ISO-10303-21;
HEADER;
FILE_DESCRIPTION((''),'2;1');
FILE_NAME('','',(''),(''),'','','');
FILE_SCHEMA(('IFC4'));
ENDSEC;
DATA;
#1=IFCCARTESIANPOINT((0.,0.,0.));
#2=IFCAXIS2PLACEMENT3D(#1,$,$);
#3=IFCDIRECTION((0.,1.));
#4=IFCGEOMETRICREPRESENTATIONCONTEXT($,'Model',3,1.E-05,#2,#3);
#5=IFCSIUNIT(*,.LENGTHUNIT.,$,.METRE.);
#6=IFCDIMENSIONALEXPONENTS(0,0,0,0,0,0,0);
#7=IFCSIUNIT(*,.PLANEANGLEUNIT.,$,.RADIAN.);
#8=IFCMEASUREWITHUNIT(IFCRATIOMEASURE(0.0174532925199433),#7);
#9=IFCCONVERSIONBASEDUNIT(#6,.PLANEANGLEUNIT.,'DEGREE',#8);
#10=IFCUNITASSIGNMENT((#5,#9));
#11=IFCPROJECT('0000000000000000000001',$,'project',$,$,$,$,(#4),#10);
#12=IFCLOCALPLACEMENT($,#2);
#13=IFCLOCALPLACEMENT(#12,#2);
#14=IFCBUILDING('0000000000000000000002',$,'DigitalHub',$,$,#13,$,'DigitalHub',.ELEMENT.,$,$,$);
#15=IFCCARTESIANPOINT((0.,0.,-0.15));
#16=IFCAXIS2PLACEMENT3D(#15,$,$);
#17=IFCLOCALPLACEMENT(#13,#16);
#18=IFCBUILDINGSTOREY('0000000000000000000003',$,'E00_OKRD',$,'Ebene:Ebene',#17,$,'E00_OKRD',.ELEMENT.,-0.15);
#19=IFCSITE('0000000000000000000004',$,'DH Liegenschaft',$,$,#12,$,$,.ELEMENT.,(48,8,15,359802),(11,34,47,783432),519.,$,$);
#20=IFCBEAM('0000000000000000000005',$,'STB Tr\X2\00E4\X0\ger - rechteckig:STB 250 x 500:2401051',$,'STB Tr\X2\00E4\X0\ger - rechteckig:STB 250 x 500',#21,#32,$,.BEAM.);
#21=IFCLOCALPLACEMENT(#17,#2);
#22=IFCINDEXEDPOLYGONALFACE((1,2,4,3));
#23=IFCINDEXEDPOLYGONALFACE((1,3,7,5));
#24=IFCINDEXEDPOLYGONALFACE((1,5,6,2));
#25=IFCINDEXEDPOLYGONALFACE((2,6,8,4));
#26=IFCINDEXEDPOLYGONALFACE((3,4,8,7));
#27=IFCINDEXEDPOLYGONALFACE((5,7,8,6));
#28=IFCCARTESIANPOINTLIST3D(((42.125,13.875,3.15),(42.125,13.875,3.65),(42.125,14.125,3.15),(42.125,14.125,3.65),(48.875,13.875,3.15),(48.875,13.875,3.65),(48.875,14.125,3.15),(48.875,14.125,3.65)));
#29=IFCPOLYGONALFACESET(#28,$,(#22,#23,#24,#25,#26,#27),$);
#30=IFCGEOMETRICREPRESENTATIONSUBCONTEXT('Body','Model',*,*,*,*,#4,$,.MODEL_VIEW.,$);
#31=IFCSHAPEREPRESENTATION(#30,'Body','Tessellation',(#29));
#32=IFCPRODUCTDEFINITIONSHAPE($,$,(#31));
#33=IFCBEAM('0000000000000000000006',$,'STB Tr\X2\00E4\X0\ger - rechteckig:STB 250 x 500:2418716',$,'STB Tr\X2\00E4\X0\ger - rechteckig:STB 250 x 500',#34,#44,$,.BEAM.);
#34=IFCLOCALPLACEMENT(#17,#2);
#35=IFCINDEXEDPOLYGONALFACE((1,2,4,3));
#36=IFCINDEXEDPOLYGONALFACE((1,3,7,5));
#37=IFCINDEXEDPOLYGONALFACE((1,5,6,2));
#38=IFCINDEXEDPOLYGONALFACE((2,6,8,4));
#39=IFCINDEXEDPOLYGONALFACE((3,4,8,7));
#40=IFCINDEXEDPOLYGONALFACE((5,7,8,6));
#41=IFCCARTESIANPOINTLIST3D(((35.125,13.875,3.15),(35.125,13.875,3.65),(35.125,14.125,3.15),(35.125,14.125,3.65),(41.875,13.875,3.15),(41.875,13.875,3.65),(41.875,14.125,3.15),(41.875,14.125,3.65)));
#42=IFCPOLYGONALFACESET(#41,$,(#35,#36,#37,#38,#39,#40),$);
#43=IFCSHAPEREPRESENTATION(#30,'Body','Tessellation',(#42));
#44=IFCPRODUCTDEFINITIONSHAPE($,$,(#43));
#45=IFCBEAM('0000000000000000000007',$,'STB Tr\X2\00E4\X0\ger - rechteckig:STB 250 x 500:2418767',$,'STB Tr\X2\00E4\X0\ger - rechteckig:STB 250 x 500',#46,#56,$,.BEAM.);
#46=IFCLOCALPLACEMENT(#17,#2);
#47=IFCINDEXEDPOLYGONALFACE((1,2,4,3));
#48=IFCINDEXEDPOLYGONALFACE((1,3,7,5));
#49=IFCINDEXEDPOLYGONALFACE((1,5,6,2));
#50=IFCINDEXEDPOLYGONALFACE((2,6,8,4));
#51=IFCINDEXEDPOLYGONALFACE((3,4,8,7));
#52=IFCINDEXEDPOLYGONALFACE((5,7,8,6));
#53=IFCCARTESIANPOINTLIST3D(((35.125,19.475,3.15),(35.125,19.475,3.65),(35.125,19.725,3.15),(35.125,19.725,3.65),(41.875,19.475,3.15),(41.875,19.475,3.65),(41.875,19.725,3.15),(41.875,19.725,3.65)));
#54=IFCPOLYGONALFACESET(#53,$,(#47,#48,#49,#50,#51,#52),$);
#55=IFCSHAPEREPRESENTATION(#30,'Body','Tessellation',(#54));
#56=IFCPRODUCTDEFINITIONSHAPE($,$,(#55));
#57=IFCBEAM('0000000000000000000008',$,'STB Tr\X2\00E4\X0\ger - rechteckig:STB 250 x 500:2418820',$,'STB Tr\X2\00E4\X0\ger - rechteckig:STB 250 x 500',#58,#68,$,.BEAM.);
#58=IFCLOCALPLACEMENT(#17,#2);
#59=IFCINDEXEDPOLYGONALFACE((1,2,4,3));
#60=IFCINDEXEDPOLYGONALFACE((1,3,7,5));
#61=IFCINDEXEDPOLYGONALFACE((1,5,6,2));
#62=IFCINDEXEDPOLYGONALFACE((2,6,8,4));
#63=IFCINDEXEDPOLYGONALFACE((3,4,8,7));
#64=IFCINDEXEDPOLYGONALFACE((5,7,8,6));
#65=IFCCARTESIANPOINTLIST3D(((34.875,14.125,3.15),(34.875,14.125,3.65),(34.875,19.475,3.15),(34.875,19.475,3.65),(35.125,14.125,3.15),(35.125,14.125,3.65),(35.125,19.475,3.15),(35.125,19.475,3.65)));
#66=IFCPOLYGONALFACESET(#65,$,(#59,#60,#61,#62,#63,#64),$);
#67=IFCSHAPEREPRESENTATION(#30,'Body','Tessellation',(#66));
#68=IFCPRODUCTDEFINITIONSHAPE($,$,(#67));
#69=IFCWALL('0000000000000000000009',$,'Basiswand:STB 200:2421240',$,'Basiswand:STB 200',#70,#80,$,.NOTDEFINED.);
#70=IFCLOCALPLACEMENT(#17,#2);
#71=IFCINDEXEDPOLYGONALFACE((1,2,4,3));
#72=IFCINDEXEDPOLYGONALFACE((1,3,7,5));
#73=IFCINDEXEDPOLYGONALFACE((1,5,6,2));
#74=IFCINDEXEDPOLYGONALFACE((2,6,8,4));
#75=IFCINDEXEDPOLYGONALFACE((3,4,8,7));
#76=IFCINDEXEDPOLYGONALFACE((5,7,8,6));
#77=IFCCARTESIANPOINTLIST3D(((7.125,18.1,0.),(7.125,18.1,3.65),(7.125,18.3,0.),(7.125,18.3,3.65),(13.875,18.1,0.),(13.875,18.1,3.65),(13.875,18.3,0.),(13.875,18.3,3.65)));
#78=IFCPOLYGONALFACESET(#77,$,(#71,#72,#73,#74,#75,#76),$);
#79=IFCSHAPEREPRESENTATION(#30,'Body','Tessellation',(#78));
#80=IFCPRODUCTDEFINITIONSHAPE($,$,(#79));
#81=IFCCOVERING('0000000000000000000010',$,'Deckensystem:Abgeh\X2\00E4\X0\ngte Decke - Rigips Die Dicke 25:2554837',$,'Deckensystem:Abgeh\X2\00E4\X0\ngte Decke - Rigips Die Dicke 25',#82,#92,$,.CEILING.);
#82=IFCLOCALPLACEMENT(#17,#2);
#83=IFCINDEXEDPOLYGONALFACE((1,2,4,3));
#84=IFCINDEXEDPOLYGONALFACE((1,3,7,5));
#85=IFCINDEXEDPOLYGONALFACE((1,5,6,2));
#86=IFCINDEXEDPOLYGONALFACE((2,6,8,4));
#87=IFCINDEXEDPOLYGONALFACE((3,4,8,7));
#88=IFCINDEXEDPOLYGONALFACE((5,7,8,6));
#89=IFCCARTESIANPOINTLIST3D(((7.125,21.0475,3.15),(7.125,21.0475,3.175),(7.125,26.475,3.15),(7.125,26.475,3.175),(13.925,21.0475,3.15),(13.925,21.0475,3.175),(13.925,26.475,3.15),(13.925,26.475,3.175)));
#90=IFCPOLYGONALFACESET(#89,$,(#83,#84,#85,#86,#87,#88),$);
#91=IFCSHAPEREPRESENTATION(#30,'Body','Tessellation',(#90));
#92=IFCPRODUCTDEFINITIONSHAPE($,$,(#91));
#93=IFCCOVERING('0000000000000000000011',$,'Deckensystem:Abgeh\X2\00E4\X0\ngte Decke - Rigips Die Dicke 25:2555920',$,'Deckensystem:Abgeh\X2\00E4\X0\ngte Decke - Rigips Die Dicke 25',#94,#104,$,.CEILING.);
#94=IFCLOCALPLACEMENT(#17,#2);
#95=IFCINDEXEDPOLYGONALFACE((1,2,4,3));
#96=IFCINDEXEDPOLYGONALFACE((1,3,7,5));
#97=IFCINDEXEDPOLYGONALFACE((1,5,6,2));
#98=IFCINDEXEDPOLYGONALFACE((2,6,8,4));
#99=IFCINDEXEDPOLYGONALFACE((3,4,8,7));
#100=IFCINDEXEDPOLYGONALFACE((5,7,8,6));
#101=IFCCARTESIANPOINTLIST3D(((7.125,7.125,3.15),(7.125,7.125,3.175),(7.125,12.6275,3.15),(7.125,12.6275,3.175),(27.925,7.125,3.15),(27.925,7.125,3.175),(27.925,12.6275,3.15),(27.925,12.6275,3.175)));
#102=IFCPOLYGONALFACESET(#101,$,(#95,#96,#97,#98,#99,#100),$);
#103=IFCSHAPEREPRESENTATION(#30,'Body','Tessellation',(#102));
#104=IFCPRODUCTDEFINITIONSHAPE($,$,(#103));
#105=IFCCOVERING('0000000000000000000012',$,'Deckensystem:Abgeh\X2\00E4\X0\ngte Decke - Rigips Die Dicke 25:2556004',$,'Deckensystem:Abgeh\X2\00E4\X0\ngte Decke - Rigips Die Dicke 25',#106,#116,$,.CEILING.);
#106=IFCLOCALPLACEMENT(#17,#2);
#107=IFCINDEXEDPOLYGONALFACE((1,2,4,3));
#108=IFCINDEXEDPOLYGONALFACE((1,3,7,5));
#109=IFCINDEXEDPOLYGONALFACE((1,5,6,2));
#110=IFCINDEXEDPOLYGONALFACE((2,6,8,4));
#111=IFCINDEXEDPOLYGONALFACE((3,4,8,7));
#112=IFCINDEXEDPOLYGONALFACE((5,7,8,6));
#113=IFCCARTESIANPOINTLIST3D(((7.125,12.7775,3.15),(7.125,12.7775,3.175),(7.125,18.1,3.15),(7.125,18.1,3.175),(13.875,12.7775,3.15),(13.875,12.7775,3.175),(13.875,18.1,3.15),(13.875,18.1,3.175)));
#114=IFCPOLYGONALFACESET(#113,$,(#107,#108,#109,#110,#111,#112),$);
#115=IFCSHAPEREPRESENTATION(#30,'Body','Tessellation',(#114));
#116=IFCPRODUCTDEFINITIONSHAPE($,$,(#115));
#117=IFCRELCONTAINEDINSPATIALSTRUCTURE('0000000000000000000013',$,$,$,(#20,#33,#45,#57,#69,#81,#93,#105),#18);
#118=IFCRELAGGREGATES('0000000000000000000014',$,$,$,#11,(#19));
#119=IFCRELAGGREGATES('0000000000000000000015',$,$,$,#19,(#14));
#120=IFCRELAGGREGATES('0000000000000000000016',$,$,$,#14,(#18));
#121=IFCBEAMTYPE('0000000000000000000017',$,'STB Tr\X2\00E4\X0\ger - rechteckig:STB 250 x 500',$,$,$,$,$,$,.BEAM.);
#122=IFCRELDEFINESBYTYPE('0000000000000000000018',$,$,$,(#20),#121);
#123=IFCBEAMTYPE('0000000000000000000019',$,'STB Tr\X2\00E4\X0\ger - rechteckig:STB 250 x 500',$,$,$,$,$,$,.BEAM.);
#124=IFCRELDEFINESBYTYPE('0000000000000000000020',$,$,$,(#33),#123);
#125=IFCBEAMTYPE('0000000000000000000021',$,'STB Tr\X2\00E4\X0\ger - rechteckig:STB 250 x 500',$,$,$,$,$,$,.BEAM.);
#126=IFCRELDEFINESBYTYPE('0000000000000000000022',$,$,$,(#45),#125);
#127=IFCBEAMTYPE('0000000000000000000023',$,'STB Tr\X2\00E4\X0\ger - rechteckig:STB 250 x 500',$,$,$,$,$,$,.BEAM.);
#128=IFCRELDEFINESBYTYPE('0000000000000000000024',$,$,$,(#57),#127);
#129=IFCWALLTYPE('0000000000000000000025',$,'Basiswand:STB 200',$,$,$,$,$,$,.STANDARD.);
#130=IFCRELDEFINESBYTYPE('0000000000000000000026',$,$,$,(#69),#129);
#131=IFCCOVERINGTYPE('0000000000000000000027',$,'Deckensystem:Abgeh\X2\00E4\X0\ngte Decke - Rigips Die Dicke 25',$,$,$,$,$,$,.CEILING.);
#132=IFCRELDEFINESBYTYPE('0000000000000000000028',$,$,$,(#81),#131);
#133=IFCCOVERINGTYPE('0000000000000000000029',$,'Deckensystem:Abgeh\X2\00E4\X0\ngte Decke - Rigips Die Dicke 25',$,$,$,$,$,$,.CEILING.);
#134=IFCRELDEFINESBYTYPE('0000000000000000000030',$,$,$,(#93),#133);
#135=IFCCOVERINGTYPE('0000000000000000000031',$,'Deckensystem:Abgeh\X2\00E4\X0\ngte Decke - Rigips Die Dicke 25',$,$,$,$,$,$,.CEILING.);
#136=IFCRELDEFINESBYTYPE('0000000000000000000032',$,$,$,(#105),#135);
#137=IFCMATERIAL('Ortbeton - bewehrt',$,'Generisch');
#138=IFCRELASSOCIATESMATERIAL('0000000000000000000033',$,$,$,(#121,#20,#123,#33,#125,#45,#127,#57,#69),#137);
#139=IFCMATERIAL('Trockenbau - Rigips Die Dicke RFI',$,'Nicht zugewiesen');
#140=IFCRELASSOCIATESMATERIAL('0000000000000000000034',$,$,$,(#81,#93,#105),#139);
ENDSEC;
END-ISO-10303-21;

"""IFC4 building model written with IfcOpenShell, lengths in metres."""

from ifc_helpers import new_model, entity, si_unit, converted_unit, direction, frame, origin, place, context, subcontext, project, spatial, indexed_curve, outline, extrude, source, transform, mapped, material, type_object, type_shapes, element, save


model = new_model("IFC4")

# Units and contexts
model_context = context("Model", 3, precision=1e-05, world=origin(), true_north=direction((0.0, 1.0)))
body_context = subcontext(model_context, "Body", "Model", "MODEL_VIEW")
ifc_project = project(units=[si_unit("LENGTHUNIT", "METRE"), converted_unit("PLANEANGLEUNIT", "DEGREE", entity("IfcRatioMeasure", 0.0174532925199433), si_unit("PLANEANGLEUNIT", "RADIAN"), dimensions=[0, 0, 0, 0, 0, 0, 0])], contexts=[model_context])

# Site, building, storey
site_placement = place(None, frame((0.0, 0.0, 0.0)))
site = spatial("IfcSite", under=ifc_project, at=site_placement, Name="DH Liegenschaft", CompositionType="ELEMENT", RefLatitude=(48, 8, 15, 359802), RefLongitude=(11, 34, 47, 783432), RefElevation=519.0)
building_placement = place(site_placement, origin())
building = spatial("IfcBuilding", under=site, at=building_placement, Name="DigitalHub", LongName="DigitalHub", CompositionType="ELEMENT")
storey_placement = place(building_placement, frame((0.0, 0.0, -0.15)))
storey = spatial("IfcBuildingStorey", under=building, at=storey_placement, Name="E00_OKRD", ObjectType="Ebene:Ebene", LongName="E00_OKRD", CompositionType="ELEMENT", Elevation=-0.15)

# Shared definitions
ifc_material_1 = material(Name="Ortbeton - bewehrt", Category="Generisch")

# Beams
beam_type_1 = type_object("IfcBeamType", Name="STB Träger - rechteckig:STB 250 x 500", PredefinedType="BEAM", material=ifc_material_1)
shared_shape_1 = source(origin(), body_context, "Body", "SweptSolid", [
    extrude(outline(indexed_curve([(-0.25, -0.125), (0.25, -0.125), (0.25, 0.125), (-0.25, 0.125), (-0.25, -0.125)], self_intersect=False)), frame((48.875, 14.0, 3.25), z_axis=(-1.0, 0.0, 0.0), x_axis=(0.0, 0.0, -1.0)), (0.0, 0.0, 1.0), 6.75),
])
type_shapes(beam_type_1, [shared_shape_1])
beam_1_placement = place(storey_placement, frame((0.0, 0.0, 0.15)))
element("IfcBeam", 1, at=beam_1_placement, inside=storey, type_object=beam_type_1, material=ifc_material_1, Name="STB Träger - rechteckig:STB 250 x 500:2401051", ObjectType="STB Träger - rechteckig:STB 250 x 500", PredefinedType="BEAM", context=body_context, shape_type="MappedRepresentation", body=[
    mapped(shared_shape_1, transform((0.0, 0.0, 0.0), scale=1.0)),
])
beam_type_2 = type_object("IfcBeamType", Name="STB Träger - rechteckig:STB 250 x 500", PredefinedType="BEAM", material=ifc_material_1)
shared_shape_2 = source(origin(), body_context, "Body", "SweptSolid", [
    extrude(outline(indexed_curve([(-0.25, -0.125), (0.25, -0.125), (0.25, 0.125), (-0.25, 0.125), (-0.25, -0.125)], self_intersect=False)), frame((41.875, 14.0, 3.25), z_axis=(-1.0, 0.0, 0.0), x_axis=(0.0, 0.0, -1.0)), (0.0, 0.0, 1.0), 6.75),
])
type_shapes(beam_type_2, [shared_shape_2])
beam_2_placement = place(storey_placement, frame((0.0, 0.0, 0.15)))
element("IfcBeam", 2, at=beam_2_placement, inside=storey, type_object=beam_type_2, material=ifc_material_1, Name="STB Träger - rechteckig:STB 250 x 500:2418716", ObjectType="STB Träger - rechteckig:STB 250 x 500", PredefinedType="BEAM", context=body_context, shape_type="MappedRepresentation", body=[
    mapped(shared_shape_2, transform((0.0, 0.0, 0.0), scale=1.0)),
])
beam_type_3 = type_object("IfcBeamType", Name="STB Träger - rechteckig:STB 250 x 500", PredefinedType="BEAM", material=ifc_material_1)
shared_shape_3 = source(origin(), body_context, "Body", "SweptSolid", [
    extrude(outline(indexed_curve([(-0.25, -0.125), (0.25, -0.125), (0.25, 0.125), (-0.25, 0.125), (-0.25, -0.125)], self_intersect=False)), frame((35.125, 19.6, 3.25), z_axis=(1.0, 0.0, 0.0), x_axis=(0.0, 0.0, -1.0)), (0.0, 0.0, 1.0), 6.75),
])
type_shapes(beam_type_3, [shared_shape_3])
beam_3_placement = place(storey_placement, frame((0.0, 0.0, 0.15)))
element("IfcBeam", 3, at=beam_3_placement, inside=storey, type_object=beam_type_3, material=ifc_material_1, Name="STB Träger - rechteckig:STB 250 x 500:2418767", ObjectType="STB Träger - rechteckig:STB 250 x 500", PredefinedType="BEAM", context=body_context, shape_type="MappedRepresentation", body=[
    mapped(shared_shape_3, transform((0.0, 0.0, 0.0), scale=1.0)),
])
beam_type_4 = type_object("IfcBeamType", Name="STB Träger - rechteckig:STB 250 x 500", PredefinedType="BEAM", material=ifc_material_1)
shared_shape_4 = source(origin(), body_context, "Body", "SweptSolid", [
    extrude(outline(indexed_curve([(-0.125, -0.25), (0.125, -0.25), (0.125, 0.25), (-0.125, 0.25), (-0.125, -0.25)], self_intersect=False)), frame((35.0, 19.475, 3.25), z_axis=(0.0, -1.0, 0.0), x_axis=(-1.0, 0.0, 0.0)), (0.0, 0.0, 1.0), 5.35),
])
type_shapes(beam_type_4, [shared_shape_4])
beam_4_placement = place(storey_placement, frame((0.0, 0.0, 0.15)))
element("IfcBeam", 4, at=beam_4_placement, inside=storey, type_object=beam_type_4, material=ifc_material_1, Name="STB Träger - rechteckig:STB 250 x 500:2418820", ObjectType="STB Träger - rechteckig:STB 250 x 500", PredefinedType="BEAM", context=body_context, shape_type="MappedRepresentation", body=[
    mapped(shared_shape_4, transform((0.0, 0.0, 0.0), scale=1.0)),
])

# Wall
wall_type_1 = type_object("IfcWallType", Name="Basiswand:STB 200", PredefinedType="STANDARD")
wall_1_placement = place(storey_placement, frame((7.125, 18.2, 0.0)))
element("IfcWall", 5, at=wall_1_placement, inside=storey, type_object=wall_type_1, material=ifc_material_1, Name="Basiswand:STB 200:2421240", ObjectType="Basiswand:STB 200", PredefinedType="NOTDEFINED", context=body_context, shape_type="SweptSolid", body=[
    extrude(outline(indexed_curve([(6.75, 0.1), (0.0, 0.1), (0.0, -0.1), (6.75, -0.1), (6.75, 0.1)], self_intersect=False)), origin(), (0.0, 0.0, 1.0), 3.65),
])

# Coverings
ifc_material_2 = material(Name="Trockenbau - Rigips Die Dicke RFI", Category="Nicht zugewiesen")
covering_type_1 = type_object("IfcCoveringType", Name="Deckensystem:Abgehängte Decke - Rigips Die Dicke 25", PredefinedType="CEILING")
covering_1_placement = place(storey_placement, frame((7.125, 21.0475, 3.15)))
element("IfcCovering", 6, at=covering_1_placement, inside=storey, type_object=covering_type_1, material=ifc_material_2, Name="Deckensystem:Abgehängte Decke - Rigips Die Dicke 25:2554837", ObjectType="Deckensystem:Abgehängte Decke - Rigips Die Dicke 25", PredefinedType="CEILING", context=body_context, shape_type="SweptSolid", body=[
    extrude(outline(indexed_curve([(-3.4, -2.7137), (3.4, -2.7137), (3.4, 2.7137), (-3.4, 2.7137), (-3.4, -2.7137)], self_intersect=False)), frame((3.4, 2.7137, 0.0), z_axis=(0.0, 0.0, 1.0), x_axis=(-1.0, 0.0, 0.0)), (0.0, 0.0, 1.0), 0.025),
])
covering_type_2 = type_object("IfcCoveringType", Name="Deckensystem:Abgehängte Decke - Rigips Die Dicke 25", PredefinedType="CEILING")
covering_2_placement = place(storey_placement, frame((7.125, 7.125, 3.15)))
element("IfcCovering", 7, at=covering_2_placement, inside=storey, type_object=covering_type_2, material=ifc_material_2, Name="Deckensystem:Abgehängte Decke - Rigips Die Dicke 25:2555920", ObjectType="Deckensystem:Abgehängte Decke - Rigips Die Dicke 25", PredefinedType="CEILING", context=body_context, shape_type="SweptSolid", body=[
    extrude(outline(indexed_curve([(-10.4, -2.7513), (10.4, -2.7513), (10.4, 2.7513), (-10.4, 2.7513), (-10.4, -2.7513)], self_intersect=False)), frame((10.4, 2.7513, 0.0), z_axis=(0.0, 0.0, 1.0), x_axis=(-1.0, 0.0, 0.0)), (0.0, 0.0, 1.0), 0.025),
])
covering_type_3 = type_object("IfcCoveringType", Name="Deckensystem:Abgehängte Decke - Rigips Die Dicke 25", PredefinedType="CEILING")
covering_3_placement = place(storey_placement, frame((7.125, 12.7775, 3.15)))
element("IfcCovering", 8, at=covering_3_placement, inside=storey, type_object=covering_type_3, material=ifc_material_2, Name="Deckensystem:Abgehängte Decke - Rigips Die Dicke 25:2556004", ObjectType="Deckensystem:Abgehängte Decke - Rigips Die Dicke 25", PredefinedType="CEILING", context=body_context, shape_type="SweptSolid", body=[
    extrude(outline(indexed_curve([(-3.375, -2.6613), (3.375, -2.6613), (3.375, 2.6613), (-3.375, 2.6613), (-3.375, -2.6613)], self_intersect=False)), frame((3.375, 2.6613, 0.0), z_axis=(0.0, 0.0, 1.0), x_axis=(-1.0, 0.0, 0.0)), (0.0, 0.0, 1.0), 0.025),
])

save(model, "model.ifc")
